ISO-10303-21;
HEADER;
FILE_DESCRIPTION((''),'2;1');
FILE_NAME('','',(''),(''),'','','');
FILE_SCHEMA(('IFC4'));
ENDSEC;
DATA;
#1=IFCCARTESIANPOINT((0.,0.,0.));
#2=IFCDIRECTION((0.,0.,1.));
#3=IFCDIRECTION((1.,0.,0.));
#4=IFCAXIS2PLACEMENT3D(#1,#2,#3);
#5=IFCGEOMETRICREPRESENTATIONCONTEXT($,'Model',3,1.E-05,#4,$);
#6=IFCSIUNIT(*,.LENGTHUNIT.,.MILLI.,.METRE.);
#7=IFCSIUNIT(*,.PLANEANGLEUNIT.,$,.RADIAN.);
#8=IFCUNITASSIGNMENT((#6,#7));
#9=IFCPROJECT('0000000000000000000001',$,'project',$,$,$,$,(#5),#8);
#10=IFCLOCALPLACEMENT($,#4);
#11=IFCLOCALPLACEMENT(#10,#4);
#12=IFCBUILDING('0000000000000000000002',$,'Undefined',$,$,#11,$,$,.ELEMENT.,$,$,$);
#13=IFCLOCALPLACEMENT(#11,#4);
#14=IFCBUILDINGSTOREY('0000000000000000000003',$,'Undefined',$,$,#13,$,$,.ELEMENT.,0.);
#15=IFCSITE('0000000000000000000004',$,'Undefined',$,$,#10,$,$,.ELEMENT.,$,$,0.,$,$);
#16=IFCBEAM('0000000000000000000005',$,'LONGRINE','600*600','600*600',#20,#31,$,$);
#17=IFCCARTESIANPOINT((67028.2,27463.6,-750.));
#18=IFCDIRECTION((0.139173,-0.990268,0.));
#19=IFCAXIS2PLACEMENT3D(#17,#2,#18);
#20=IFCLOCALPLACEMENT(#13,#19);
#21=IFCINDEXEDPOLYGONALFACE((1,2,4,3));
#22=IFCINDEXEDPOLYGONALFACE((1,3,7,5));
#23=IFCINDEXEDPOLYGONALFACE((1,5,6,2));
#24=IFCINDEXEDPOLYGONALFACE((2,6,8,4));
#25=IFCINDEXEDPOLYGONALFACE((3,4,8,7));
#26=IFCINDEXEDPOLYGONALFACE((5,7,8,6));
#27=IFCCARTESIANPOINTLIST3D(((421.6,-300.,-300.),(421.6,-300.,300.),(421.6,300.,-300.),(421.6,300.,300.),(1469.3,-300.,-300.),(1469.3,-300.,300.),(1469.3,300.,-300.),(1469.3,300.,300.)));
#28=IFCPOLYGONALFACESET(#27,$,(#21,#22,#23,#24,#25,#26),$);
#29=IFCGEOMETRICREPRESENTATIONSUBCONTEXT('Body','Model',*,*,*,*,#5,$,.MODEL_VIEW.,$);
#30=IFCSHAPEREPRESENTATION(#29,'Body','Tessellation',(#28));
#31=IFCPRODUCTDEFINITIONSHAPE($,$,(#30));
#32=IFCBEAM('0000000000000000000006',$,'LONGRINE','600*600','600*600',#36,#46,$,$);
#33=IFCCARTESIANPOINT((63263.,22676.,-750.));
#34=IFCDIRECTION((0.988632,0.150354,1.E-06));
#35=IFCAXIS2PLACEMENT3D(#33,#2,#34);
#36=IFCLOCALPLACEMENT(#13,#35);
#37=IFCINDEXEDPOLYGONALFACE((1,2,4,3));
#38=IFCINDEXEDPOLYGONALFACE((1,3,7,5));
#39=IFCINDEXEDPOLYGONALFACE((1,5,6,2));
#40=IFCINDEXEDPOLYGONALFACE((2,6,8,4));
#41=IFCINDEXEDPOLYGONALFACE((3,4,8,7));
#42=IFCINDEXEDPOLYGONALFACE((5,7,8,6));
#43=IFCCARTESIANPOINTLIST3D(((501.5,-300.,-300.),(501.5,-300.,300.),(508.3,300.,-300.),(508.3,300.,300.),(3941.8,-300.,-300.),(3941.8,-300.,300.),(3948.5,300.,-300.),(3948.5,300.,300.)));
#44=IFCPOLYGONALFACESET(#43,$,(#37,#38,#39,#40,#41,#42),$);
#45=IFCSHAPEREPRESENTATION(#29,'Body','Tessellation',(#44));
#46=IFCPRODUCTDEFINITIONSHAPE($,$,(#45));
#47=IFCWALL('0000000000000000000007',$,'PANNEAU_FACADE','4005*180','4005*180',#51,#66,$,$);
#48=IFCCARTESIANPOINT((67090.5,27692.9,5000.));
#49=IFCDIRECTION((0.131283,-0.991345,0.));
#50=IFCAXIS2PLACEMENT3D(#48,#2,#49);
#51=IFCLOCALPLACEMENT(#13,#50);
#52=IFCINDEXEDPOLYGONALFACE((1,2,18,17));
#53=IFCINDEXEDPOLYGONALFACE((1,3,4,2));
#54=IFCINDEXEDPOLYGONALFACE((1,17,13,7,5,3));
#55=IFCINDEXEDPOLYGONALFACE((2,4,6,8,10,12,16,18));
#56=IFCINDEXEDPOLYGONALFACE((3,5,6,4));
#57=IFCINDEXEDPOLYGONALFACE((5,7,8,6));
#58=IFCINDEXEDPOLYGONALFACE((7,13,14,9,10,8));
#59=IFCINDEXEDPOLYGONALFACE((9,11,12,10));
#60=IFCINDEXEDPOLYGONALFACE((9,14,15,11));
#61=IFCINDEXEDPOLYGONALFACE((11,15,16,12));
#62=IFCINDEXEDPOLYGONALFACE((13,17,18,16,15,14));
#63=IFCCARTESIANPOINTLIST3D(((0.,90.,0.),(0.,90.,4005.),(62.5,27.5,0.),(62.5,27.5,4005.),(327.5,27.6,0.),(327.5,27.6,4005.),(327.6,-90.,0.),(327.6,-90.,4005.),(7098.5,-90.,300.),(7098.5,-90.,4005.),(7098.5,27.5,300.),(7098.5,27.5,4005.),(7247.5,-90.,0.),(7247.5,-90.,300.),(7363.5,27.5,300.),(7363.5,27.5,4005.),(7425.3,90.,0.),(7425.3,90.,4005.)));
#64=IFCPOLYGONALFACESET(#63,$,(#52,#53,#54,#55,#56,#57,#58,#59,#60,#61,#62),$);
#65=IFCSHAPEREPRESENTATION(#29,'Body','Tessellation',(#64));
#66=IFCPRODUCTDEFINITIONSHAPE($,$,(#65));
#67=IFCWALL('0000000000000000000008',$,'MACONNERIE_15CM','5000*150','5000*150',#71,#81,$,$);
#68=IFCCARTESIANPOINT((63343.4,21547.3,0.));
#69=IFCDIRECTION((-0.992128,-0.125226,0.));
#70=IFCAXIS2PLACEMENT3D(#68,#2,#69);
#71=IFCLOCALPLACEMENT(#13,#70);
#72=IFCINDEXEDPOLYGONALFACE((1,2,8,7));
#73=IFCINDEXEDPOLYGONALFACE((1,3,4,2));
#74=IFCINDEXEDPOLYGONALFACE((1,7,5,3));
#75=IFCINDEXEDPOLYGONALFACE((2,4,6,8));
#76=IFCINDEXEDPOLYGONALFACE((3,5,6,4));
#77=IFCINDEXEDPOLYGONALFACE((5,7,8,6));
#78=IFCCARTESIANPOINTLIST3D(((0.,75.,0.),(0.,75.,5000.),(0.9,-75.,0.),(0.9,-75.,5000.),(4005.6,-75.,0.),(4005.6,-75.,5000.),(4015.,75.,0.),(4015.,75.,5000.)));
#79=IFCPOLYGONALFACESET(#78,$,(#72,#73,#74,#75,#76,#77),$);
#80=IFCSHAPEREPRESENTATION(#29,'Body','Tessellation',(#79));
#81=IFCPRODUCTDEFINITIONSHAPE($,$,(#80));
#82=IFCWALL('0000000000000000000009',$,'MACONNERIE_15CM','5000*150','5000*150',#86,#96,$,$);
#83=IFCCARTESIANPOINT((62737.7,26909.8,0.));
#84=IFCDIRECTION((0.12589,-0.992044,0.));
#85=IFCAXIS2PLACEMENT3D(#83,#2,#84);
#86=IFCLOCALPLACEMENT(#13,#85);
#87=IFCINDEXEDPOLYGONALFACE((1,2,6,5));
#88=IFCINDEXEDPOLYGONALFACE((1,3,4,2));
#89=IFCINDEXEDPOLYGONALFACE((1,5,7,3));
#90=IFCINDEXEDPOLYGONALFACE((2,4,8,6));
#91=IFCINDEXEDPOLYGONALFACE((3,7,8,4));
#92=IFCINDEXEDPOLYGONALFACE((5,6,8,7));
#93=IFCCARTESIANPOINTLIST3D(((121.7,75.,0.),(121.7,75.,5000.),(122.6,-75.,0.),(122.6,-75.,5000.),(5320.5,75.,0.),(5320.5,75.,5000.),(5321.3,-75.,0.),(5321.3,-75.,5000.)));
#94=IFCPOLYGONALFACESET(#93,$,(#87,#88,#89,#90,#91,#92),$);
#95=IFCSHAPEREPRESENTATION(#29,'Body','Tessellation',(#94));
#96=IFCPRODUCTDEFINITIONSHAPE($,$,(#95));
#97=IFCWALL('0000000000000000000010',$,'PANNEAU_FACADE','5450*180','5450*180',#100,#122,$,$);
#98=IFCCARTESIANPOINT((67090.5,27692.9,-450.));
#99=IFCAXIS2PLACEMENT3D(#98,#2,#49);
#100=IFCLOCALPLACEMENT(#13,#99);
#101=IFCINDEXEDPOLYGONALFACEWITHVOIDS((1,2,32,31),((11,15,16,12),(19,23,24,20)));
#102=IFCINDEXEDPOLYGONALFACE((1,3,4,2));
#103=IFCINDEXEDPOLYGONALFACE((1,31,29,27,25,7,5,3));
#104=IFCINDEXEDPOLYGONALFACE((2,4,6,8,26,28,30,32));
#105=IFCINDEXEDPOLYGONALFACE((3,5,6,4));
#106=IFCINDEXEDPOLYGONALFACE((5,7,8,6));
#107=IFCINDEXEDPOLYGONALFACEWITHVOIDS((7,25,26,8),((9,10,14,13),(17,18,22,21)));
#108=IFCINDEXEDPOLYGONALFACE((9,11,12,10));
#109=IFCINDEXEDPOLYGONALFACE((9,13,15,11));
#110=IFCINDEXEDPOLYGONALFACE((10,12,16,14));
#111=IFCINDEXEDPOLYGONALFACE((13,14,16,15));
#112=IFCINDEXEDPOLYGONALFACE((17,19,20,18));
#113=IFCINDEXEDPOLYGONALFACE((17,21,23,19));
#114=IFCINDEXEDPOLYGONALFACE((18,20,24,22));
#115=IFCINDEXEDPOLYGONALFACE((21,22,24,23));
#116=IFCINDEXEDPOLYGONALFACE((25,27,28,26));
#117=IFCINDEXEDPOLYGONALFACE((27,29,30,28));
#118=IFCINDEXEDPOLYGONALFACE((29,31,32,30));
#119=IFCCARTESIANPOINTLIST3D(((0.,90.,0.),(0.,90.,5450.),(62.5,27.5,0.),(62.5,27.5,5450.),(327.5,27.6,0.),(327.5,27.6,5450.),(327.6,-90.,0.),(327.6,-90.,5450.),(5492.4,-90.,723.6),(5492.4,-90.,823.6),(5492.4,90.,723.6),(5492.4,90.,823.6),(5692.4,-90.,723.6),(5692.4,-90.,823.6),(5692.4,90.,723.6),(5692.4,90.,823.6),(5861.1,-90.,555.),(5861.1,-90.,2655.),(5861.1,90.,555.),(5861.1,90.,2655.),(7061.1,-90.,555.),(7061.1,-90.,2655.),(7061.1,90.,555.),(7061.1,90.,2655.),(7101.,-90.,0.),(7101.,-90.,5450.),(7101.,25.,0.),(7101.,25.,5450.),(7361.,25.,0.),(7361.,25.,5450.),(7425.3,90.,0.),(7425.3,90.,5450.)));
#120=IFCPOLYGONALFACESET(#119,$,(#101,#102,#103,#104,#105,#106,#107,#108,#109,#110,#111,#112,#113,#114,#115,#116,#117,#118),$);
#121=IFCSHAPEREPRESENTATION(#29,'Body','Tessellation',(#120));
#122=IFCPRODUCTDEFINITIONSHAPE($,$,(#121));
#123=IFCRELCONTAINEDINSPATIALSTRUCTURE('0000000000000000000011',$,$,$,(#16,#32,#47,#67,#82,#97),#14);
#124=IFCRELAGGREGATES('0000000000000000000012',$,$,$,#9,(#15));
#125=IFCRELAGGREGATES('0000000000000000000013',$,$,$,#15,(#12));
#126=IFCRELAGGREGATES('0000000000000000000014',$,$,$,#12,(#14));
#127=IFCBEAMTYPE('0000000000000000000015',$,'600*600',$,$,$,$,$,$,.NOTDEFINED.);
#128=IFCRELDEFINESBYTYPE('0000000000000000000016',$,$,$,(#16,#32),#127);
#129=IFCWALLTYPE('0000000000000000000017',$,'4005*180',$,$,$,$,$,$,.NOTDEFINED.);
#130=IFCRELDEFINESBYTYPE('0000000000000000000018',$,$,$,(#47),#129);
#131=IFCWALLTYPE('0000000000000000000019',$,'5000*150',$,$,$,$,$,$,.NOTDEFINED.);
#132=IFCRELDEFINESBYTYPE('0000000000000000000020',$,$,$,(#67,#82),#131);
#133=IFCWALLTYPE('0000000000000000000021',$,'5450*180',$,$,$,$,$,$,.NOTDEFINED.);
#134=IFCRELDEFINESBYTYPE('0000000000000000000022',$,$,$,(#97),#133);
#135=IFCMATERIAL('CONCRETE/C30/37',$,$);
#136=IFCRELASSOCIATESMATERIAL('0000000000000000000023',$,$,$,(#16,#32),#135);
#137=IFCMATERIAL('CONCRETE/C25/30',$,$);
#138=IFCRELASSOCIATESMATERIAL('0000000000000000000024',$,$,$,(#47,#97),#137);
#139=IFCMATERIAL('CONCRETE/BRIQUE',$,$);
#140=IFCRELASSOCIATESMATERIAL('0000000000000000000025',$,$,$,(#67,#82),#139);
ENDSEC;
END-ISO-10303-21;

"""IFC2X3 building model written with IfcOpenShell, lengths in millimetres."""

from ifc_helpers import new_model, si_unit, frame, frame_2d, origin_with_axes, origin_2d_with_axis, place, context, subcontext, project, spatial, polyline, rectangle, outline, extrude, boolean, clip, halfspace, material, type_object, element, save


model = new_model("IFC2X3")

# Units and contexts
model_context = context("Model", 3, precision=1e-05, world=origin_with_axes())
body_context = subcontext(model_context, "Body", "Model", "MODEL_VIEW")
ifc_project = project(units=[si_unit("LENGTHUNIT", "METRE", prefix="MILLI"), si_unit("PLANEANGLEUNIT", "RADIAN")], contexts=[model_context])

# Site, building, storey
site_placement = place(None, origin_with_axes())
site = spatial("IfcSite", under=ifc_project, at=site_placement, Name="Undefined", CompositionType="ELEMENT", RefElevation=0.0)
building_placement = place(site_placement, origin_with_axes())
building = spatial("IfcBuilding", under=site, at=building_placement, Name="Undefined", CompositionType="ELEMENT")
storey_placement = place(building_placement, origin_with_axes())
storey = spatial("IfcBuildingStorey", under=building, at=storey_placement, Name="Undefined", CompositionType="ELEMENT", Elevation=0.0)

# Shared definitions
ifc_material_1 = material(Name="CONCRETE/C30/37")
ifc_material_2 = material(Name="CONCRETE/C25/30")

# Beams
beam_type_1 = type_object("IfcBeamType", Name="600*600", PredefinedType="NOTDEFINED")
beam_1_placement = place(storey_placement, frame((67028.2, 27463.6, -750.0), z_axis=(0.0, 0.0, 1.0), x_axis=(0.139173, -0.990268, 0.0)))
element("IfcBeam", 1, at=beam_1_placement, inside=storey, type_object=beam_type_1, material=ifc_material_1, Name="LONGRINE", Description="600*600", ObjectType="600*600", context=body_context, shape_type="SweptSolid", body=[
    extrude(rectangle(XDim=600.0, YDim=600.0, at=origin_2d_with_axis()), frame((1469.3, 0.0, 0.0), z_axis=(-1.0, 0.0, 0.0), x_axis=(0.0, -1.0, 0.0)), (0.0, 0.0, 1.0), 1047.7),
])
beam_2_placement = place(storey_placement, frame((63263.0, 22676.0, -750.0), z_axis=(0.0, 0.0, 1.0), x_axis=(0.988632, 0.150354, 0.000001)))
element("IfcBeam", 2, at=beam_2_placement, inside=storey, type_object=beam_type_1, material=ifc_material_1, Name="LONGRINE", Description="600*600", ObjectType="600*600", context=body_context, shape_type="Clipping", body=[
    clip(clip(extrude(rectangle(XDim=600.0, YDim=600.0, at=origin_2d_with_axis()), frame((4118.8, 0.0, 0.0), z_axis=(-1.0, 0.0, 0.0), x_axis=(0.0, -1.0, 0.0)), (0.0, 0.0, 1.0), 3787.5), halfspace(frame((3945.2, 0.0, -1000.0), z_axis=(-0.999936, 0.011299, 0.000001), x_axis=(0.011299, 0.999936, 0.0)), True)), halfspace(frame((504.9, 0.0, -1000.0), z_axis=(0.999936, -0.011299, -0.000001), x_axis=(-0.011299, -0.999936, 0.0)), True)),
])

# Walls
wall_type_1 = type_object("IfcWallType", Name="4005*180", PredefinedType="NOTDEFINED")
wall_1_placement = place(storey_placement, frame((67090.5, 27692.9, 5000.0), z_axis=(0.0, 0.0, 1.0), x_axis=(0.131283, -0.991345, 0.0)))
element("IfcWall", 3, at=wall_1_placement, inside=storey, type_object=wall_type_1, material=ifc_material_2, Name="PANNEAU_FACADE", Description="4005*180", ObjectType="4005*180", context=body_context, shape_type="CSG", body=[
    boolean("DIFFERENCE", boolean("DIFFERENCE", boolean("DIFFERENCE", boolean("DIFFERENCE", extrude(rectangle(XDim=8111.9, YDim=180.0, at=frame_2d((0.0, 3713.2), x_axis=(0.0, -1.0))), frame((0.0, 0.0, 0.0), z_axis=(0.0, 0.0, 1.0), x_axis=(0.0, -1.0, 0.0)), (0.0, 0.0, 1.0), 4005.0), extrude(rectangle(XDim=265.0, YDim=265.0, at=origin_2d_with_axis()), frame((7231.0, -105.0, 4005.0), z_axis=(0.0, 0.0, -1.0), x_axis=(-1.0, 0.0, 0.0)), (0.0, 0.0, 1.0), 3705.0)), extrude(rectangle(XDim=265.0, YDim=265.0, at=origin_2d_with_axis()), frame((195.1, -104.9, 4005.0), z_axis=(0.0, 0.0, -1.0), x_axis=(-1.0, -0.000448, 0.0)), (0.0, 0.0, 1.0), 4005.0)), halfspace(frame((7425.3, 90.0, 2002.5), z_axis=(-0.711444, 0.702742, 0.0), x_axis=(0.0, 0.0, 1.0)), True)), halfspace(frame((0.0, 90.0, 2002.5), z_axis=(-0.706948, -0.707265, 0.0), x_axis=(0.0, 0.0, 1.0)), False)),
])
ifc_material_3 = material(Name="CONCRETE/BRIQUE")
wall_type_2 = type_object("IfcWallType", Name="5000*150", PredefinedType="NOTDEFINED")
wall_2_placement = place(storey_placement, frame((63343.4, 21547.3, 0.0), z_axis=(0.0, 0.0, 1.0), x_axis=(-0.992128, -0.125226, 0.0)))
element("IfcWall", 4, at=wall_2_placement, inside=storey, type_object=wall_type_2, material=ifc_material_3, Name="MACONNERIE_15CM", Description="5000*150", ObjectType="5000*150", context=body_context, shape_type="Clipping", body=[
    clip(clip(extrude(rectangle(XDim=4155.7, YDim=150.0, at=frame_2d((0.0, 2005.4), x_axis=(0.0, -1.0))), frame((0.0, 0.0, 0.0), z_axis=(0.0, 0.0, 1.0), x_axis=(0.0, -1.0, 0.0)), (0.0, 0.0, 1.0), 5000.0), halfspace(frame((4005.6, -75.0, 2500.0), z_axis=(0.99803, -0.062737, 0.0), x_axis=(0.0, 0.0, 1.0)), False)), halfspace(frame((0.5, 0.0, 1500.0), z_axis=(0.999981, 0.006128, 0.0), x_axis=(0.006128, -0.999981, 0.0)), True)),
])
wall_3_placement = place(storey_placement, frame((62737.7, 26909.8, 0.0), z_axis=(0.0, 0.0, 1.0), x_axis=(0.12589, -0.992044, 0.0)))
element("IfcWall", 5, at=wall_3_placement, inside=storey, type_object=wall_type_2, material=ifc_material_3, Name="MACONNERIE_15CM", Description="5000*150", ObjectType="5000*150", context=body_context, shape_type="Clipping", body=[
    clip(clip(extrude(rectangle(XDim=5367.3, YDim=150.0, at=frame_2d((0.0, 2721.5), x_axis=(0.0, -1.0))), frame((0.0, 0.0, 0.0), z_axis=(0.0, 0.0, 1.0), x_axis=(0.0, -1.0, 0.0)), (0.0, 0.0, 1.0), 5000.0), halfspace(frame((5320.9, 0.0, 1500.0), z_axis=(-0.999985, -0.005459, 0.0), x_axis=(-0.005459, 0.999985, 0.0)), True)), halfspace(frame((122.1, 0.0, 1500.0), z_axis=(0.999983, 0.005886, 0.0), x_axis=(0.005886, -0.999983, 0.0)), True)),
])
wall_type_3 = type_object("IfcWallType", Name="5450*180", PredefinedType="NOTDEFINED")
wall_4_placement = place(storey_placement, frame((67090.5, 27692.9, -450.0), z_axis=(0.0, 0.0, 1.0), x_axis=(0.131283, -0.991345, 0.0)))
solid_1 = boolean("DIFFERENCE", extrude(rectangle(XDim=265.0, YDim=265.0, at=origin_2d_with_axis()), frame((7231.0, -105.0, 5450.0), z_axis=(0.0, 0.0, -1.0), x_axis=(-1.0, 0.0, 0.0)), (0.0, 0.0, 1.0), 5450.0), extrude(rectangle(XDim=265.0, YDim=265.0, at=origin_2d_with_axis()), frame((7231.0, -105.0, 5450.0), z_axis=(0.0, 0.0, -1.0), x_axis=(-1.0, 0.0, 0.0)), (0.0, 0.0, 1.0), 5450.0))
element("IfcWall", 6, at=wall_4_placement, inside=storey, type_object=wall_type_3, material=ifc_material_2, Name="PANNEAU_FACADE", Description="5450*180", ObjectType="5450*180", context=body_context, shape_type="CSG", body=[
    boolean("DIFFERENCE", boolean("DIFFERENCE", boolean("DIFFERENCE", boolean("DIFFERENCE", boolean("DIFFERENCE", boolean("DIFFERENCE", boolean("DIFFERENCE", extrude(rectangle(XDim=8111.9, YDim=180.0, at=frame_2d((0.0, 3713.2), x_axis=(0.0, -1.0))), frame((0.0, 0.0, 0.0), z_axis=(0.0, 0.0, 1.0), x_axis=(0.0, -1.0, 0.0)), (0.0, 0.0, 1.0), 5450.0), extrude(rectangle(XDim=200.0, YDim=100.0, at=origin_2d_with_axis()), frame((5592.4, -100.0, 773.6), z_axis=(0.0, 1.0, 0.0), x_axis=(-1.0, 0.0, 0.0)), (0.0, 0.0, 1.0), 200.0)), extrude(rectangle(XDim=260.0, YDim=260.0, at=origin_2d_with_axis()), frame((7231.0, -105.0, 5450.0), z_axis=(0.0, 0.0, -1.0), x_axis=(-1.0, 0.0, 0.0)), (0.0, 0.0, 1.0), 5450.0)), solid_1), extrude(rectangle(XDim=265.0, YDim=265.0, at=origin_2d_with_axis()), frame((195.1, -104.9, 5450.0), z_axis=(0.0, 0.0, -1.0), x_axis=(-1.0, -0.000448, 0.0)), (0.0, 0.0, 1.0), 5450.0)), extrude(outline(polyline([(0.0, 0.0), (2100.0, 0.0), (2100.0, 1200.0), (0.0, 1200.0), (0.0, 0.0)])), frame((7061.1, -100.0, 2655.0), z_axis=(0.0, 1.0, 0.0), x_axis=(0.0, 0.0, -1.0)), (0.0, 0.0, 1.0), 200.0)), halfspace(frame((7425.3, 90.0, 7452.5), z_axis=(-0.711444, 0.702742, 0.0), x_axis=(0.0, 0.0, 1.0)), True)), halfspace(frame((0.0, 90.0, 2725.0), z_axis=(-0.706948, -0.707265, 0.0), x_axis=(0.0, 0.0, 1.0)), False)),
])

save(model, "model.ifc")
